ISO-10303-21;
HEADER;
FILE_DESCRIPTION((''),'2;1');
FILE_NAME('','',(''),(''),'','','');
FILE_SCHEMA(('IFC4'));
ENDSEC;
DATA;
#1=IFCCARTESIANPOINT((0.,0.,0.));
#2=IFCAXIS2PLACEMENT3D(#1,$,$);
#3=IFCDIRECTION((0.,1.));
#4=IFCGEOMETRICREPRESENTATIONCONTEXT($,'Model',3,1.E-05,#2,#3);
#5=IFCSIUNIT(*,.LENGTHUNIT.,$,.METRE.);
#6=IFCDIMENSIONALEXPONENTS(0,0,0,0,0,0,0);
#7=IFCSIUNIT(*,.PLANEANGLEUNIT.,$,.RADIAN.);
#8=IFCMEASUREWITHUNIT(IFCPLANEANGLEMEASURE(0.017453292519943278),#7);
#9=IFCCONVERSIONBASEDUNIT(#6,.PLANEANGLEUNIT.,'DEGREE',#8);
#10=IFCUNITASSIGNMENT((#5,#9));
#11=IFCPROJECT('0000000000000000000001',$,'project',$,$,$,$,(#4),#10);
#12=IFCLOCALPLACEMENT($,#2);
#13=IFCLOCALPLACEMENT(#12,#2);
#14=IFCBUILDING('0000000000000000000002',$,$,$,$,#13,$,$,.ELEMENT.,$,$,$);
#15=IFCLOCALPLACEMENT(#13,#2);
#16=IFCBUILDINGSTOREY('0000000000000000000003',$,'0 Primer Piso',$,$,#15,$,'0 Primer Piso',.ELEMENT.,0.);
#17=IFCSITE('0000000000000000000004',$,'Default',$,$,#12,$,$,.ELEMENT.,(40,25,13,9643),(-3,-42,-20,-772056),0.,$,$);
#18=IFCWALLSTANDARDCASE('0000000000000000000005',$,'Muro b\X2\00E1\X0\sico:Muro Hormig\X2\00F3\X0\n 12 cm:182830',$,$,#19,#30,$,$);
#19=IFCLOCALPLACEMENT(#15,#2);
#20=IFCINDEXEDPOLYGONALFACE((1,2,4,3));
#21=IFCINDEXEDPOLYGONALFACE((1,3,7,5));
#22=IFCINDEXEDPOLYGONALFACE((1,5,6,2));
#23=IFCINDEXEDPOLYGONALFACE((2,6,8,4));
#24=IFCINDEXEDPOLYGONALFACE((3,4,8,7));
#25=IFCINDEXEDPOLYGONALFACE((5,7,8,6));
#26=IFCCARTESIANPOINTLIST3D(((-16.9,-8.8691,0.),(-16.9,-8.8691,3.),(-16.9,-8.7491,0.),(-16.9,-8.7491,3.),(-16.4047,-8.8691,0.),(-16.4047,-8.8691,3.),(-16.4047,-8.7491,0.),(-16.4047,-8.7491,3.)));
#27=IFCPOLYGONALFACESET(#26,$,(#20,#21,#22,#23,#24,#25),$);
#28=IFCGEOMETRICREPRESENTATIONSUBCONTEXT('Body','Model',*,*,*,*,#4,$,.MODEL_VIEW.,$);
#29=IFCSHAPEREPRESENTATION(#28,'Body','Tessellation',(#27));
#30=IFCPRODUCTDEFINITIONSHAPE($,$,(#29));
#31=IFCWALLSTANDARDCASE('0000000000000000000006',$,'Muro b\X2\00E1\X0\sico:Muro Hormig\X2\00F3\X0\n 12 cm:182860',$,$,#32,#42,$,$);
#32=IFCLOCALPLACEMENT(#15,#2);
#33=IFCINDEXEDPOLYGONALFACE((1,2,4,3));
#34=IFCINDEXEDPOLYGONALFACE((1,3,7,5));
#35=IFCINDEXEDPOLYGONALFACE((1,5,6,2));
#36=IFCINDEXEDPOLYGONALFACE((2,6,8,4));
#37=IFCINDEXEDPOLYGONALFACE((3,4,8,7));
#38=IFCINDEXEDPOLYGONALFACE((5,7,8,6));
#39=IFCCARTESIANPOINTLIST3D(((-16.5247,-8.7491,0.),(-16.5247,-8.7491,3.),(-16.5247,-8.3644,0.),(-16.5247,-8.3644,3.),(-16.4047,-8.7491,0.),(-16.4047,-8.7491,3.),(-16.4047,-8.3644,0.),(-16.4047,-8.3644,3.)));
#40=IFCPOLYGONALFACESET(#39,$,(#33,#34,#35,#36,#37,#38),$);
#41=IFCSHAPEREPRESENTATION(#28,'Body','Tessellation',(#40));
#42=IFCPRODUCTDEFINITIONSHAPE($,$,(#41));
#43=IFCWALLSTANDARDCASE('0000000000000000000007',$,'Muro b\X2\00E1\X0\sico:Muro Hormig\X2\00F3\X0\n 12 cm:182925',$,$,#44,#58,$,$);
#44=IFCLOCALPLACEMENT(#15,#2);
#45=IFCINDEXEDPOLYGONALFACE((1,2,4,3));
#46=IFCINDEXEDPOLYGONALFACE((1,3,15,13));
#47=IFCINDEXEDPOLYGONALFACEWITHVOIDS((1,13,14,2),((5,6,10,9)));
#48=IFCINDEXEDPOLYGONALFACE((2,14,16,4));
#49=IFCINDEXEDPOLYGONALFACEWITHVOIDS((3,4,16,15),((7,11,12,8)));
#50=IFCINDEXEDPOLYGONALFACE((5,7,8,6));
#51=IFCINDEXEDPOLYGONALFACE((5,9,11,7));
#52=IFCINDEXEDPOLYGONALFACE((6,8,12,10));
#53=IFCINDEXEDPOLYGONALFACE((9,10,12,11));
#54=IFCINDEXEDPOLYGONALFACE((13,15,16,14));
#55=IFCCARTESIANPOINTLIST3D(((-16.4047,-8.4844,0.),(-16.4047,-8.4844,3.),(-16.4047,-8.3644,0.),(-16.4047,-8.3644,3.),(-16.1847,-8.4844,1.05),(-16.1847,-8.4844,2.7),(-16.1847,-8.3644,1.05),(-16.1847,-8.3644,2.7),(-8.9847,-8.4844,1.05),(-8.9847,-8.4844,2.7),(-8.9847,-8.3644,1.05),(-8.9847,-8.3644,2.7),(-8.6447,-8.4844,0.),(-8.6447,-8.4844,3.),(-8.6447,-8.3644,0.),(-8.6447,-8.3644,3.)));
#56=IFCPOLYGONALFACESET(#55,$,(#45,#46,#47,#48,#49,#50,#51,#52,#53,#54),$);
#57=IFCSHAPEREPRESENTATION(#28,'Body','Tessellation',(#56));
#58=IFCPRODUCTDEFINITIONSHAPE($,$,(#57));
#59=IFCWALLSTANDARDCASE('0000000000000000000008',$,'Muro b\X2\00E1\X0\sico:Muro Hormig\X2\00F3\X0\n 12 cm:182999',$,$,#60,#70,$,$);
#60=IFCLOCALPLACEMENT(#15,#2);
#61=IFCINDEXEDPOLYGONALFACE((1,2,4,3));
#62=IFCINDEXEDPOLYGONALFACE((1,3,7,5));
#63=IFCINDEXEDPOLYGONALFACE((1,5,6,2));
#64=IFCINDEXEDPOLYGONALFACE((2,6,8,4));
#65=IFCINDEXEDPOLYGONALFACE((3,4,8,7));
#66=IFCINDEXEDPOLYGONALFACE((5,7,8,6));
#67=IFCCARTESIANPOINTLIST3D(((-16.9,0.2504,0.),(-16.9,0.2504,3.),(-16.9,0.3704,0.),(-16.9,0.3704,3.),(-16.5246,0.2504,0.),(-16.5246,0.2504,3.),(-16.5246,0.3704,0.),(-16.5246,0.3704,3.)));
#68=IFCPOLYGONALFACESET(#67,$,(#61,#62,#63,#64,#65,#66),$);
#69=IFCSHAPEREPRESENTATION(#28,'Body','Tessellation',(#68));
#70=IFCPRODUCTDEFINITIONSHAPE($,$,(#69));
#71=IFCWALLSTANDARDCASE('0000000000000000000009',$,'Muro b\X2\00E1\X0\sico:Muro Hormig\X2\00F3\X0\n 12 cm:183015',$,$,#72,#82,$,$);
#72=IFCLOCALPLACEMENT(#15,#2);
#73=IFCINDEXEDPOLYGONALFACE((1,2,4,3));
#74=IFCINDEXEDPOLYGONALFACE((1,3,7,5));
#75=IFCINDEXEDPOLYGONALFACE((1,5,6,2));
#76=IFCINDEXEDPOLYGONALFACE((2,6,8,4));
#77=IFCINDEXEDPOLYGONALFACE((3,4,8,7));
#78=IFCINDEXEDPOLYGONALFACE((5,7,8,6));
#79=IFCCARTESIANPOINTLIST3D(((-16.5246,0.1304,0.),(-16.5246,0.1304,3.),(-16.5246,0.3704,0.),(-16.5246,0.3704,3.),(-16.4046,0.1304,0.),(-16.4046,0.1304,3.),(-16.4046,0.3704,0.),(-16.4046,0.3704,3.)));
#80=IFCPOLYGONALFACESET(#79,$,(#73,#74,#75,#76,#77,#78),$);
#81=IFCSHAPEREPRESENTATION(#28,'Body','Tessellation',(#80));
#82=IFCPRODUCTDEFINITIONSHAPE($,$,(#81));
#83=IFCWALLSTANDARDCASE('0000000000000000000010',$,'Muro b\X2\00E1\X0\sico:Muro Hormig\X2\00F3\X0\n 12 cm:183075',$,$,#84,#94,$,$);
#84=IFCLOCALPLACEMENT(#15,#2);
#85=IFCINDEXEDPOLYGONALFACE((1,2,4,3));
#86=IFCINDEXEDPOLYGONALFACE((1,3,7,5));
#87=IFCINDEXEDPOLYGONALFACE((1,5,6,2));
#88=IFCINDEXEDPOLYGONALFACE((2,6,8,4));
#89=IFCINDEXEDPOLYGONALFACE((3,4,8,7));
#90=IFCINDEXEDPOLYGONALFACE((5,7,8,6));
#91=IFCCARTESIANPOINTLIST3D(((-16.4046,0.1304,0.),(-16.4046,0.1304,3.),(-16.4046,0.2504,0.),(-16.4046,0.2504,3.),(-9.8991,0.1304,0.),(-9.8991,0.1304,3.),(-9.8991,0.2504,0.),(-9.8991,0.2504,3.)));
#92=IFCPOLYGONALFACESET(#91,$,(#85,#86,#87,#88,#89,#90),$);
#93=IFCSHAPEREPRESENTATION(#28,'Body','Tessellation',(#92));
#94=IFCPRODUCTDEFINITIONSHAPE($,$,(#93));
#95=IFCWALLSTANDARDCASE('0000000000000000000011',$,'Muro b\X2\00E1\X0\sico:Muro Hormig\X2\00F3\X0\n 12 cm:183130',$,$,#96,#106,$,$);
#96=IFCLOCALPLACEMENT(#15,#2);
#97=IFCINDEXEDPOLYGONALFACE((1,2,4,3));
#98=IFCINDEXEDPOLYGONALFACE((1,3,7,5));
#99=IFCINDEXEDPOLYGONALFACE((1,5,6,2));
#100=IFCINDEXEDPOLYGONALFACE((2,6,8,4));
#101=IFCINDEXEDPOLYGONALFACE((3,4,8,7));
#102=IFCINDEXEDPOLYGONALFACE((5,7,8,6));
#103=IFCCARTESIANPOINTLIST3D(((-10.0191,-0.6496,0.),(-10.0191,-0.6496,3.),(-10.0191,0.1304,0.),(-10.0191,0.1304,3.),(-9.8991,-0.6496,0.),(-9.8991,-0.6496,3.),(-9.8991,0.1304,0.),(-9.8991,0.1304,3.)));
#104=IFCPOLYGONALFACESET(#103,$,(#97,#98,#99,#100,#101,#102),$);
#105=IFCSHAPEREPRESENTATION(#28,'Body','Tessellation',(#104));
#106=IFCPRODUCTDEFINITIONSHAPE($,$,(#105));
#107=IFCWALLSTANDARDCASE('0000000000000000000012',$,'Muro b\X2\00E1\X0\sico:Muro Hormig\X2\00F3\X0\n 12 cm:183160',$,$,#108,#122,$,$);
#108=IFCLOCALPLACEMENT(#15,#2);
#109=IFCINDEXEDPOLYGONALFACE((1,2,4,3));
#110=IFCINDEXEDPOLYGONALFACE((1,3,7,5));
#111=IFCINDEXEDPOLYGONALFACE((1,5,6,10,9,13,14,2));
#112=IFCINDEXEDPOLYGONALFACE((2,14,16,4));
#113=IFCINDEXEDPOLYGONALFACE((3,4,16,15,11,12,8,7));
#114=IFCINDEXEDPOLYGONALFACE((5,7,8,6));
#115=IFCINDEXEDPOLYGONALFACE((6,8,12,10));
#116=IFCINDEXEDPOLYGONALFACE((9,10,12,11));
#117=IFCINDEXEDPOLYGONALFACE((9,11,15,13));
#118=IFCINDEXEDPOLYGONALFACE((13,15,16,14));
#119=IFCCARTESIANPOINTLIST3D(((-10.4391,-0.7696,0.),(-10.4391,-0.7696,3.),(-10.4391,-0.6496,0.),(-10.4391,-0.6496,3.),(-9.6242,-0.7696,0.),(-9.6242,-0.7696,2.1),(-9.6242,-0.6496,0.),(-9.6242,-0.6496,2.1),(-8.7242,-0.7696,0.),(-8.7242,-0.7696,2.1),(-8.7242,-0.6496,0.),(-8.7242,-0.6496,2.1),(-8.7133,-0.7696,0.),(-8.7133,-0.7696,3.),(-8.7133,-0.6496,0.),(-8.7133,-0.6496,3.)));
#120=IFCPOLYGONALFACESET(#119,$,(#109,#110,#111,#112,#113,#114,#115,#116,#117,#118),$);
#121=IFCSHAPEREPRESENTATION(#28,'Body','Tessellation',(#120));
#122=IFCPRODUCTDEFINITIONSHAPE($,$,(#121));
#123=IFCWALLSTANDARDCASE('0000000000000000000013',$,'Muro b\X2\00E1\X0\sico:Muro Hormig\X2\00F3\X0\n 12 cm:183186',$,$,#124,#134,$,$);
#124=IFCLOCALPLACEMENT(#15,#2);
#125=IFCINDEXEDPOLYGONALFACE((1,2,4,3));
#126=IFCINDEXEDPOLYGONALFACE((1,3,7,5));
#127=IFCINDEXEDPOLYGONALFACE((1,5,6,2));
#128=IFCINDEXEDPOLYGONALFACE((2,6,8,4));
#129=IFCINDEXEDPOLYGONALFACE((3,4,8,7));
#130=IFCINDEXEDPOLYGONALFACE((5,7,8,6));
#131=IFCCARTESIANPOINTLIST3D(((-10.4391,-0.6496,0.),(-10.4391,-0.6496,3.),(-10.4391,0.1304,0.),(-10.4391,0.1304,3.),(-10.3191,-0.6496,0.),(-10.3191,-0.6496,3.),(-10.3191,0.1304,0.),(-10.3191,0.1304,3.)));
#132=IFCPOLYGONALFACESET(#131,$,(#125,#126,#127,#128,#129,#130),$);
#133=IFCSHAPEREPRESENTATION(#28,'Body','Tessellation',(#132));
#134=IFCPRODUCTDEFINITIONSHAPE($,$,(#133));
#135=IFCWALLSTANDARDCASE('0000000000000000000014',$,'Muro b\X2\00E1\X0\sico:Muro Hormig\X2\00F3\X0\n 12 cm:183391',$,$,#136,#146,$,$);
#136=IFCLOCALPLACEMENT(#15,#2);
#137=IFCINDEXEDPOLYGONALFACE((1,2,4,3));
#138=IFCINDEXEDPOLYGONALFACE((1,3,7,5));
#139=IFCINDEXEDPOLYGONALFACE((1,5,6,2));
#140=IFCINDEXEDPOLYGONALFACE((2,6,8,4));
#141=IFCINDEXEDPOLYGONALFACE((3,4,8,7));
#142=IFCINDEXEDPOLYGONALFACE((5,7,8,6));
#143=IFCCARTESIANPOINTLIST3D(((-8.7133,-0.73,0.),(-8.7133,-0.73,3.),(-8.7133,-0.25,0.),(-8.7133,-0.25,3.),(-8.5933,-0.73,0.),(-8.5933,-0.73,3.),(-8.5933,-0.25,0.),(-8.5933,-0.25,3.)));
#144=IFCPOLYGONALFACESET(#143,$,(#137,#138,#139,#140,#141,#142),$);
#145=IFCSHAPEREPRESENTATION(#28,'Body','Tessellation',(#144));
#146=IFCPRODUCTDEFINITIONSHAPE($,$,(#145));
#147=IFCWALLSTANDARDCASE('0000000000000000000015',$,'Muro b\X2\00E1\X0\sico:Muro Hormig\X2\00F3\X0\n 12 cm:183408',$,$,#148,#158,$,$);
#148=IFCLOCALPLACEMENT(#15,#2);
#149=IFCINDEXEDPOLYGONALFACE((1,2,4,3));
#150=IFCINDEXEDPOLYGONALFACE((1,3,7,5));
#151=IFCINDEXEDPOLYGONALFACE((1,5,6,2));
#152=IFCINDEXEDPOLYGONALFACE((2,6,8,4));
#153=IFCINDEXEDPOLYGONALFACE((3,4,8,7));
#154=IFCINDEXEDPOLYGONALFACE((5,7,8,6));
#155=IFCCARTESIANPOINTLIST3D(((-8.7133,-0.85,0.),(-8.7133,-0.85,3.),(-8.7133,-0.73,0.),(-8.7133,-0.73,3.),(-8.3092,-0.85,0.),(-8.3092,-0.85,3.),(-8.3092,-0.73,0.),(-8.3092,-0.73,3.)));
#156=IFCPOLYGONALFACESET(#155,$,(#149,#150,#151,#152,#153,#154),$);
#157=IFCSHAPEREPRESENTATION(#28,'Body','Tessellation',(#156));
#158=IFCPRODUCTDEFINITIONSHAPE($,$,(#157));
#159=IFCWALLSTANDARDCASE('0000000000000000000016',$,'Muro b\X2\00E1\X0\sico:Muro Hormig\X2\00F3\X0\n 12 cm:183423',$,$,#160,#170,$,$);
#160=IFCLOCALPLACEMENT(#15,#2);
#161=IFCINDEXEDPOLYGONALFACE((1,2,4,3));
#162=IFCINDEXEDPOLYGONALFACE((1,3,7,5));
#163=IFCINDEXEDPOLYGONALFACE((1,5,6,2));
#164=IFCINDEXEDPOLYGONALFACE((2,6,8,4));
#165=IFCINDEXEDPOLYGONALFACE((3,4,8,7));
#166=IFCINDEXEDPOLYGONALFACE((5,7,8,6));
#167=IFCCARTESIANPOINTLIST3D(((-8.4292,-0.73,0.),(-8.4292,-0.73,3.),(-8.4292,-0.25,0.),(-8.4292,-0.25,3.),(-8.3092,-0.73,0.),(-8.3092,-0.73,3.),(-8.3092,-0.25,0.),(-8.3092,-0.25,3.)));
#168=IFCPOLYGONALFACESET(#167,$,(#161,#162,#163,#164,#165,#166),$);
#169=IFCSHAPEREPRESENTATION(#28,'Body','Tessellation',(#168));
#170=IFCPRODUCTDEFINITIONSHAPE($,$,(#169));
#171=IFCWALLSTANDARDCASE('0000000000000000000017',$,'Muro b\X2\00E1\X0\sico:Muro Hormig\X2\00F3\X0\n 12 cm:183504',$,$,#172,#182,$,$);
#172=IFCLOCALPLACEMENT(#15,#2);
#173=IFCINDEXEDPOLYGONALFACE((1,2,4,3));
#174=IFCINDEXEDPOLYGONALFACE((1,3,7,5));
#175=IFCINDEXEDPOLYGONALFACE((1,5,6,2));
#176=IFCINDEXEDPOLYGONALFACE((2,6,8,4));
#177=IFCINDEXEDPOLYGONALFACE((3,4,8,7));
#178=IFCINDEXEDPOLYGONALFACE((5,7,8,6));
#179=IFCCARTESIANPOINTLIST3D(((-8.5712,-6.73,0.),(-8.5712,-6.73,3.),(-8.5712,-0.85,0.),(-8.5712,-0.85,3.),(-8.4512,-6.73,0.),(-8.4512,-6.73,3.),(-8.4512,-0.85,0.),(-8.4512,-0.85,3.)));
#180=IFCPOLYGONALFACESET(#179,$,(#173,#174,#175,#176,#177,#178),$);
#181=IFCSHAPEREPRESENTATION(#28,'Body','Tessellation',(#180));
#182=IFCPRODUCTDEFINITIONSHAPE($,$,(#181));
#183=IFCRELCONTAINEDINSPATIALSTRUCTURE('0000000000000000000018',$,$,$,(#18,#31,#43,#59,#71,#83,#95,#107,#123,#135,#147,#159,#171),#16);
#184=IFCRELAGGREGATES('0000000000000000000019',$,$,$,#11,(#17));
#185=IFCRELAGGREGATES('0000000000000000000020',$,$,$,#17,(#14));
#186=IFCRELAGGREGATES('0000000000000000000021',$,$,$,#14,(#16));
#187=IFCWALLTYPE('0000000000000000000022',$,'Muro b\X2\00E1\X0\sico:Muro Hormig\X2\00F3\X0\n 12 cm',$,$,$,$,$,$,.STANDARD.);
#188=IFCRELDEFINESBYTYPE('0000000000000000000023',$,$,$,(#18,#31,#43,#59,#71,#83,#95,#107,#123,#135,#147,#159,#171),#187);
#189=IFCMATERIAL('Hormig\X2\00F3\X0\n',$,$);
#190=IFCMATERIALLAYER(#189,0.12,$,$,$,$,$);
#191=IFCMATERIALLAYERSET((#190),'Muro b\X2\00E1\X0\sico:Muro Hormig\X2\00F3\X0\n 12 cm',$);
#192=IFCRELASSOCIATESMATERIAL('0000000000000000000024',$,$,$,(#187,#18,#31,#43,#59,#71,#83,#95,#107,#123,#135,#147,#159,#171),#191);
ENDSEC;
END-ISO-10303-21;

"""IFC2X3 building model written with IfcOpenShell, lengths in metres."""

from ifc_helpers import new_model, entity, si_unit, converted_unit, direction, frame, frame_2d, origin, place, context, subcontext, project, spatial, rectangle, extrude, material, layer, layer_set, layer_usage, type_object, element, save


model = new_model("IFC2X3")

# Units and contexts
model_context = context("Model", 3, precision=1e-05, world=origin(), true_north=direction((0.0, 1.0)))
body_context = subcontext(model_context, "Body", "Model", "MODEL_VIEW")
ifc_project = project(units=[si_unit("LENGTHUNIT", "METRE"), converted_unit("PLANEANGLEUNIT", "DEGREE", entity("IfcPlaneAngleMeasure", 0.017453292519943278), si_unit("PLANEANGLEUNIT", "RADIAN"), dimensions=[0, 0, 0, 0, 0, 0, 0])], contexts=[model_context])

# Site, building, storey
site_placement = place(None, origin())
site = spatial("IfcSite", under=ifc_project, at=site_placement, Name="Default", CompositionType="ELEMENT", RefLatitude=(40, 25, 13, 9643), RefLongitude=(-3, -42, -20, -772056), RefElevation=0.0)
building_placement = place(site_placement, origin())
building = spatial("IfcBuilding", under=site, at=building_placement, CompositionType="ELEMENT")
storey_placement = place(building_placement, origin())
storey = spatial("IfcBuildingStorey", under=building, at=storey_placement, Name="0 Primer Piso", LongName="0 Primer Piso", CompositionType="ELEMENT", Elevation=0.0)

# Walls
ifc_material_1 = material(Name="Hormigón")
ifc_layer_1 = layer(ifc_material_1, 0.12)
ifc_layer_set_1 = layer_set([ifc_layer_1], Name="Muro básico:Muro Hormigón 12 cm")
ifc_layer_usage_1 = layer_usage(ifc_layer_set_1, "AXIS2", "NEGATIVE", 0.06)
wall_type = type_object("IfcWallType", Name="Muro básico:Muro Hormigón 12 cm", PredefinedType="STANDARD", material=ifc_layer_set_1)
wall_1_placement = place(storey_placement, frame((-16.9, -8.8091, 0.0)))
element("IfcWallStandardCase", 1, at=wall_1_placement, inside=storey, type_object=wall_type, material=ifc_layer_usage_1, Name="Muro básico:Muro Hormigón 12 cm:182830", context=body_context, shape_type="SweptSolid", body=[
    extrude(rectangle(XDim=0.4953, YDim=0.12, at=frame_2d((0.2476, 0.0), x_axis=(-1.0, 0.0))), origin(), (0.0, 0.0, 1.0), 3.0),
])
ifc_layer_usage_2 = layer_usage(ifc_layer_set_1, "AXIS2", "NEGATIVE", 0.06)
wall_2_placement = place(storey_placement, frame((-16.4647, -8.7491, 0.0), z_axis=(0.0, 0.0, 1.0), x_axis=(0.0, 1.0, 0.0)))
element("IfcWallStandardCase", 2, at=wall_2_placement, inside=storey, type_object=wall_type, material=ifc_layer_usage_2, Name="Muro básico:Muro Hormigón 12 cm:182860", context=body_context, shape_type="SweptSolid", body=[
    extrude(rectangle(XDim=0.3847, YDim=0.12, at=frame_2d((0.1923, 0.0), x_axis=(-1.0, 0.0))), origin(), (0.0, 0.0, 1.0), 3.0),
])

# Wall, opening
ifc_layer_usage_3 = layer_usage(ifc_layer_set_1, "AXIS2", "NEGATIVE", 0.06)
wall_3_placement = place(storey_placement, frame((-16.4047, -8.4244, 0.0)))
wall_3 = element("IfcWallStandardCase", 3, at=wall_3_placement, inside=storey, type_object=wall_type, material=ifc_layer_usage_3, Name="Muro básico:Muro Hormigón 12 cm:182925", context=body_context, shape_type="SweptSolid", body=[
    extrude(rectangle(XDim=7.76, YDim=0.12, at=frame_2d((3.88, 0.0), x_axis=(-1.0, 0.0))), origin(), (0.0, 0.0, 1.0), 3.0),
])
opening_1_placement = place(wall_3_placement, frame((0.22, -0.06, 1.05)))
element("IfcOpeningElement", 4, at=opening_1_placement, cuts=wall_3, ObjectType="Opening", context=body_context, shape_type="SweptSolid", body=[
    extrude(rectangle(XDim=1.65, YDim=7.2, at=frame_2d((0.825, 3.6), x_axis=(1.0, 0.0))), frame((0.0, 0.0, 0.0), z_axis=(0.0, 1.0, 0.0), x_axis=(0.0, 0.0, 1.0)), (0.0, 0.0, 1.0), 0.12),
])

# Walls
ifc_layer_usage_4 = layer_usage(ifc_layer_set_1, "AXIS2", "NEGATIVE", 0.06)
wall_4_placement = place(storey_placement, frame((-16.9, 0.3104, 0.0)))
element("IfcWallStandardCase", 5, at=wall_4_placement, inside=storey, type_object=wall_type, material=ifc_layer_usage_4, Name="Muro básico:Muro Hormigón 12 cm:182999", context=body_context, shape_type="SweptSolid", body=[
    extrude(rectangle(XDim=0.3754, YDim=0.12, at=frame_2d((0.1877, 0.0), x_axis=(-1.0, 0.0))), origin(), (0.0, 0.0, 1.0), 3.0),
])
ifc_layer_usage_5 = layer_usage(ifc_layer_set_1, "AXIS2", "NEGATIVE", 0.06)
wall_5_placement = place(storey_placement, frame((-16.4646, 0.3704, 0.0), z_axis=(0.0, 0.0, 1.0), x_axis=(0.0, -1.0, 0.0)))
element("IfcWallStandardCase", 6, at=wall_5_placement, inside=storey, type_object=wall_type, material=ifc_layer_usage_5, Name="Muro básico:Muro Hormigón 12 cm:183015", context=body_context, shape_type="SweptSolid", body=[
    extrude(rectangle(XDim=0.24, YDim=0.12, at=frame_2d((0.12, 0.0), x_axis=(-1.0, 0.0))), origin(), (0.0, 0.0, 1.0), 3.0),
])
ifc_layer_usage_6 = layer_usage(ifc_layer_set_1, "AXIS2", "NEGATIVE", 0.06)
wall_6_placement = place(storey_placement, frame((-16.4046, 0.1904, 0.0)))
element("IfcWallStandardCase", 7, at=wall_6_placement, inside=storey, type_object=wall_type, material=ifc_layer_usage_6, Name="Muro básico:Muro Hormigón 12 cm:183075", context=body_context, shape_type="SweptSolid", body=[
    extrude(rectangle(XDim=6.5054, YDim=0.12, at=frame_2d((3.2527, 0.0), x_axis=(-1.0, 0.0))), origin(), (0.0, 0.0, 1.0), 3.0),
])
ifc_layer_usage_7 = layer_usage(ifc_layer_set_1, "AXIS2", "NEGATIVE", 0.06)
wall_7_placement = place(storey_placement, frame((-9.9591, 0.1304, 0.0), z_axis=(0.0, 0.0, 1.0), x_axis=(0.0, -1.0, 0.0)))
element("IfcWallStandardCase", 8, at=wall_7_placement, inside=storey, type_object=wall_type, material=ifc_layer_usage_7, Name="Muro básico:Muro Hormigón 12 cm:183130", context=body_context, shape_type="SweptSolid", body=[
    extrude(rectangle(XDim=0.78, YDim=0.12, at=frame_2d((0.39, 0.0), x_axis=(-1.0, 0.0))), origin(), (0.0, 0.0, 1.0), 3.0),
])

# Wall, opening
ifc_layer_usage_8 = layer_usage(ifc_layer_set_1, "AXIS2", "NEGATIVE", 0.06)
wall_8_placement = place(storey_placement, frame((-8.7133, -0.7096, 0.0), z_axis=(0.0, 0.0, 1.0), x_axis=(-1.0, 0.0, 0.0)))
wall_8 = element("IfcWallStandardCase", 9, at=wall_8_placement, inside=storey, type_object=wall_type, material=ifc_layer_usage_8, Name="Muro básico:Muro Hormigón 12 cm:183160", context=body_context, shape_type="SweptSolid", body=[
    extrude(rectangle(XDim=1.7259, YDim=0.12, at=frame_2d((0.8629, 0.0), x_axis=(1.0, 0.0))), origin(), (0.0, 0.0, 1.0), 3.0),
])
opening_2_placement = place(wall_8_placement, frame((0.9109, 0.06, 0.0)))
element("IfcOpeningElement", 10, at=opening_2_placement, cuts=wall_8, ObjectType="Opening", context=body_context, shape_type="SweptSolid", body=[
    extrude(rectangle(XDim=2.1, YDim=0.9, at=frame_2d((1.05, 0.45), x_axis=(1.0, 0.0))), frame((0.0, 0.0, 0.0), z_axis=(0.0, -1.0, 0.0), x_axis=(0.0, 0.0, 1.0)), (0.0, 0.0, 1.0), 0.12),
])

# Walls
ifc_layer_usage_9 = layer_usage(ifc_layer_set_1, "AXIS2", "NEGATIVE", 0.06)
wall_9_placement = place(storey_placement, frame((-10.3791, -0.6496, 0.0), z_axis=(0.0, 0.0, 1.0), x_axis=(0.0, 1.0, 0.0)))
element("IfcWallStandardCase", 11, at=wall_9_placement, inside=storey, type_object=wall_type, material=ifc_layer_usage_9, Name="Muro básico:Muro Hormigón 12 cm:183186", context=body_context, shape_type="SweptSolid", body=[
    extrude(rectangle(XDim=0.78, YDim=0.12, at=frame_2d((0.39, 0.0), x_axis=(-1.0, 0.0))), origin(), (0.0, 0.0, 1.0), 3.0),
])
ifc_layer_usage_10 = layer_usage(ifc_layer_set_1, "AXIS2", "NEGATIVE", 0.06)
wall_10_placement = place(storey_placement, frame((-8.6533, -0.25, 0.0), z_axis=(0.0, 0.0, 1.0), x_axis=(0.0, -1.0, 0.0)))
element("IfcWallStandardCase", 12, at=wall_10_placement, inside=storey, type_object=wall_type, material=ifc_layer_usage_10, Name="Muro básico:Muro Hormigón 12 cm:183391", context=body_context, shape_type="SweptSolid", body=[
    extrude(rectangle(XDim=0.48, YDim=0.12, at=frame_2d((0.24, 0.0), x_axis=(-1.0, 0.0))), origin(), (0.0, 0.0, 1.0), 3.0),
])
ifc_layer_usage_11 = layer_usage(ifc_layer_set_1, "AXIS2", "NEGATIVE", 0.06)
wall_11_placement = place(storey_placement, frame((-8.7133, -0.79, 0.0)))
element("IfcWallStandardCase", 13, at=wall_11_placement, inside=storey, type_object=wall_type, material=ifc_layer_usage_11, Name="Muro básico:Muro Hormigón 12 cm:183408", context=body_context, shape_type="SweptSolid", body=[
    extrude(rectangle(XDim=0.4041, YDim=0.12, at=frame_2d((0.2021, 0.0), x_axis=(-1.0, 0.0))), origin(), (0.0, 0.0, 1.0), 3.0),
])
ifc_layer_usage_12 = layer_usage(ifc_layer_set_1, "AXIS2", "NEGATIVE", 0.06)
wall_12_placement = place(storey_placement, frame((-8.3692, -0.73, 0.0), z_axis=(0.0, 0.0, 1.0), x_axis=(0.0, 1.0, 0.0)))
element("IfcWallStandardCase", 14, at=wall_12_placement, inside=storey, type_object=wall_type, material=ifc_layer_usage_12, Name="Muro básico:Muro Hormigón 12 cm:183423", context=body_context, shape_type="SweptSolid", body=[
    extrude(rectangle(XDim=0.48, YDim=0.12, at=frame_2d((0.24, 0.0), x_axis=(-1.0, 0.0))), origin(), (0.0, 0.0, 1.0), 3.0),
])
ifc_layer_usage_13 = layer_usage(ifc_layer_set_1, "AXIS2", "NEGATIVE", 0.06)
wall_13_placement = place(storey_placement, frame((-8.5112, -0.85, 0.0), z_axis=(0.0, 0.0, 1.0), x_axis=(0.0, -1.0, 0.0)))
element("IfcWallStandardCase", 15, at=wall_13_placement, inside=storey, type_object=wall_type, material=ifc_layer_usage_13, Name="Muro básico:Muro Hormigón 12 cm:183504", context=body_context, shape_type="SweptSolid", body=[
    extrude(rectangle(XDim=5.88, YDim=0.12, at=frame_2d((2.94, 0.0), x_axis=(-1.0, 0.0))), origin(), (0.0, 0.0, 1.0), 3.0),
])

save(model, "model.ifc")
